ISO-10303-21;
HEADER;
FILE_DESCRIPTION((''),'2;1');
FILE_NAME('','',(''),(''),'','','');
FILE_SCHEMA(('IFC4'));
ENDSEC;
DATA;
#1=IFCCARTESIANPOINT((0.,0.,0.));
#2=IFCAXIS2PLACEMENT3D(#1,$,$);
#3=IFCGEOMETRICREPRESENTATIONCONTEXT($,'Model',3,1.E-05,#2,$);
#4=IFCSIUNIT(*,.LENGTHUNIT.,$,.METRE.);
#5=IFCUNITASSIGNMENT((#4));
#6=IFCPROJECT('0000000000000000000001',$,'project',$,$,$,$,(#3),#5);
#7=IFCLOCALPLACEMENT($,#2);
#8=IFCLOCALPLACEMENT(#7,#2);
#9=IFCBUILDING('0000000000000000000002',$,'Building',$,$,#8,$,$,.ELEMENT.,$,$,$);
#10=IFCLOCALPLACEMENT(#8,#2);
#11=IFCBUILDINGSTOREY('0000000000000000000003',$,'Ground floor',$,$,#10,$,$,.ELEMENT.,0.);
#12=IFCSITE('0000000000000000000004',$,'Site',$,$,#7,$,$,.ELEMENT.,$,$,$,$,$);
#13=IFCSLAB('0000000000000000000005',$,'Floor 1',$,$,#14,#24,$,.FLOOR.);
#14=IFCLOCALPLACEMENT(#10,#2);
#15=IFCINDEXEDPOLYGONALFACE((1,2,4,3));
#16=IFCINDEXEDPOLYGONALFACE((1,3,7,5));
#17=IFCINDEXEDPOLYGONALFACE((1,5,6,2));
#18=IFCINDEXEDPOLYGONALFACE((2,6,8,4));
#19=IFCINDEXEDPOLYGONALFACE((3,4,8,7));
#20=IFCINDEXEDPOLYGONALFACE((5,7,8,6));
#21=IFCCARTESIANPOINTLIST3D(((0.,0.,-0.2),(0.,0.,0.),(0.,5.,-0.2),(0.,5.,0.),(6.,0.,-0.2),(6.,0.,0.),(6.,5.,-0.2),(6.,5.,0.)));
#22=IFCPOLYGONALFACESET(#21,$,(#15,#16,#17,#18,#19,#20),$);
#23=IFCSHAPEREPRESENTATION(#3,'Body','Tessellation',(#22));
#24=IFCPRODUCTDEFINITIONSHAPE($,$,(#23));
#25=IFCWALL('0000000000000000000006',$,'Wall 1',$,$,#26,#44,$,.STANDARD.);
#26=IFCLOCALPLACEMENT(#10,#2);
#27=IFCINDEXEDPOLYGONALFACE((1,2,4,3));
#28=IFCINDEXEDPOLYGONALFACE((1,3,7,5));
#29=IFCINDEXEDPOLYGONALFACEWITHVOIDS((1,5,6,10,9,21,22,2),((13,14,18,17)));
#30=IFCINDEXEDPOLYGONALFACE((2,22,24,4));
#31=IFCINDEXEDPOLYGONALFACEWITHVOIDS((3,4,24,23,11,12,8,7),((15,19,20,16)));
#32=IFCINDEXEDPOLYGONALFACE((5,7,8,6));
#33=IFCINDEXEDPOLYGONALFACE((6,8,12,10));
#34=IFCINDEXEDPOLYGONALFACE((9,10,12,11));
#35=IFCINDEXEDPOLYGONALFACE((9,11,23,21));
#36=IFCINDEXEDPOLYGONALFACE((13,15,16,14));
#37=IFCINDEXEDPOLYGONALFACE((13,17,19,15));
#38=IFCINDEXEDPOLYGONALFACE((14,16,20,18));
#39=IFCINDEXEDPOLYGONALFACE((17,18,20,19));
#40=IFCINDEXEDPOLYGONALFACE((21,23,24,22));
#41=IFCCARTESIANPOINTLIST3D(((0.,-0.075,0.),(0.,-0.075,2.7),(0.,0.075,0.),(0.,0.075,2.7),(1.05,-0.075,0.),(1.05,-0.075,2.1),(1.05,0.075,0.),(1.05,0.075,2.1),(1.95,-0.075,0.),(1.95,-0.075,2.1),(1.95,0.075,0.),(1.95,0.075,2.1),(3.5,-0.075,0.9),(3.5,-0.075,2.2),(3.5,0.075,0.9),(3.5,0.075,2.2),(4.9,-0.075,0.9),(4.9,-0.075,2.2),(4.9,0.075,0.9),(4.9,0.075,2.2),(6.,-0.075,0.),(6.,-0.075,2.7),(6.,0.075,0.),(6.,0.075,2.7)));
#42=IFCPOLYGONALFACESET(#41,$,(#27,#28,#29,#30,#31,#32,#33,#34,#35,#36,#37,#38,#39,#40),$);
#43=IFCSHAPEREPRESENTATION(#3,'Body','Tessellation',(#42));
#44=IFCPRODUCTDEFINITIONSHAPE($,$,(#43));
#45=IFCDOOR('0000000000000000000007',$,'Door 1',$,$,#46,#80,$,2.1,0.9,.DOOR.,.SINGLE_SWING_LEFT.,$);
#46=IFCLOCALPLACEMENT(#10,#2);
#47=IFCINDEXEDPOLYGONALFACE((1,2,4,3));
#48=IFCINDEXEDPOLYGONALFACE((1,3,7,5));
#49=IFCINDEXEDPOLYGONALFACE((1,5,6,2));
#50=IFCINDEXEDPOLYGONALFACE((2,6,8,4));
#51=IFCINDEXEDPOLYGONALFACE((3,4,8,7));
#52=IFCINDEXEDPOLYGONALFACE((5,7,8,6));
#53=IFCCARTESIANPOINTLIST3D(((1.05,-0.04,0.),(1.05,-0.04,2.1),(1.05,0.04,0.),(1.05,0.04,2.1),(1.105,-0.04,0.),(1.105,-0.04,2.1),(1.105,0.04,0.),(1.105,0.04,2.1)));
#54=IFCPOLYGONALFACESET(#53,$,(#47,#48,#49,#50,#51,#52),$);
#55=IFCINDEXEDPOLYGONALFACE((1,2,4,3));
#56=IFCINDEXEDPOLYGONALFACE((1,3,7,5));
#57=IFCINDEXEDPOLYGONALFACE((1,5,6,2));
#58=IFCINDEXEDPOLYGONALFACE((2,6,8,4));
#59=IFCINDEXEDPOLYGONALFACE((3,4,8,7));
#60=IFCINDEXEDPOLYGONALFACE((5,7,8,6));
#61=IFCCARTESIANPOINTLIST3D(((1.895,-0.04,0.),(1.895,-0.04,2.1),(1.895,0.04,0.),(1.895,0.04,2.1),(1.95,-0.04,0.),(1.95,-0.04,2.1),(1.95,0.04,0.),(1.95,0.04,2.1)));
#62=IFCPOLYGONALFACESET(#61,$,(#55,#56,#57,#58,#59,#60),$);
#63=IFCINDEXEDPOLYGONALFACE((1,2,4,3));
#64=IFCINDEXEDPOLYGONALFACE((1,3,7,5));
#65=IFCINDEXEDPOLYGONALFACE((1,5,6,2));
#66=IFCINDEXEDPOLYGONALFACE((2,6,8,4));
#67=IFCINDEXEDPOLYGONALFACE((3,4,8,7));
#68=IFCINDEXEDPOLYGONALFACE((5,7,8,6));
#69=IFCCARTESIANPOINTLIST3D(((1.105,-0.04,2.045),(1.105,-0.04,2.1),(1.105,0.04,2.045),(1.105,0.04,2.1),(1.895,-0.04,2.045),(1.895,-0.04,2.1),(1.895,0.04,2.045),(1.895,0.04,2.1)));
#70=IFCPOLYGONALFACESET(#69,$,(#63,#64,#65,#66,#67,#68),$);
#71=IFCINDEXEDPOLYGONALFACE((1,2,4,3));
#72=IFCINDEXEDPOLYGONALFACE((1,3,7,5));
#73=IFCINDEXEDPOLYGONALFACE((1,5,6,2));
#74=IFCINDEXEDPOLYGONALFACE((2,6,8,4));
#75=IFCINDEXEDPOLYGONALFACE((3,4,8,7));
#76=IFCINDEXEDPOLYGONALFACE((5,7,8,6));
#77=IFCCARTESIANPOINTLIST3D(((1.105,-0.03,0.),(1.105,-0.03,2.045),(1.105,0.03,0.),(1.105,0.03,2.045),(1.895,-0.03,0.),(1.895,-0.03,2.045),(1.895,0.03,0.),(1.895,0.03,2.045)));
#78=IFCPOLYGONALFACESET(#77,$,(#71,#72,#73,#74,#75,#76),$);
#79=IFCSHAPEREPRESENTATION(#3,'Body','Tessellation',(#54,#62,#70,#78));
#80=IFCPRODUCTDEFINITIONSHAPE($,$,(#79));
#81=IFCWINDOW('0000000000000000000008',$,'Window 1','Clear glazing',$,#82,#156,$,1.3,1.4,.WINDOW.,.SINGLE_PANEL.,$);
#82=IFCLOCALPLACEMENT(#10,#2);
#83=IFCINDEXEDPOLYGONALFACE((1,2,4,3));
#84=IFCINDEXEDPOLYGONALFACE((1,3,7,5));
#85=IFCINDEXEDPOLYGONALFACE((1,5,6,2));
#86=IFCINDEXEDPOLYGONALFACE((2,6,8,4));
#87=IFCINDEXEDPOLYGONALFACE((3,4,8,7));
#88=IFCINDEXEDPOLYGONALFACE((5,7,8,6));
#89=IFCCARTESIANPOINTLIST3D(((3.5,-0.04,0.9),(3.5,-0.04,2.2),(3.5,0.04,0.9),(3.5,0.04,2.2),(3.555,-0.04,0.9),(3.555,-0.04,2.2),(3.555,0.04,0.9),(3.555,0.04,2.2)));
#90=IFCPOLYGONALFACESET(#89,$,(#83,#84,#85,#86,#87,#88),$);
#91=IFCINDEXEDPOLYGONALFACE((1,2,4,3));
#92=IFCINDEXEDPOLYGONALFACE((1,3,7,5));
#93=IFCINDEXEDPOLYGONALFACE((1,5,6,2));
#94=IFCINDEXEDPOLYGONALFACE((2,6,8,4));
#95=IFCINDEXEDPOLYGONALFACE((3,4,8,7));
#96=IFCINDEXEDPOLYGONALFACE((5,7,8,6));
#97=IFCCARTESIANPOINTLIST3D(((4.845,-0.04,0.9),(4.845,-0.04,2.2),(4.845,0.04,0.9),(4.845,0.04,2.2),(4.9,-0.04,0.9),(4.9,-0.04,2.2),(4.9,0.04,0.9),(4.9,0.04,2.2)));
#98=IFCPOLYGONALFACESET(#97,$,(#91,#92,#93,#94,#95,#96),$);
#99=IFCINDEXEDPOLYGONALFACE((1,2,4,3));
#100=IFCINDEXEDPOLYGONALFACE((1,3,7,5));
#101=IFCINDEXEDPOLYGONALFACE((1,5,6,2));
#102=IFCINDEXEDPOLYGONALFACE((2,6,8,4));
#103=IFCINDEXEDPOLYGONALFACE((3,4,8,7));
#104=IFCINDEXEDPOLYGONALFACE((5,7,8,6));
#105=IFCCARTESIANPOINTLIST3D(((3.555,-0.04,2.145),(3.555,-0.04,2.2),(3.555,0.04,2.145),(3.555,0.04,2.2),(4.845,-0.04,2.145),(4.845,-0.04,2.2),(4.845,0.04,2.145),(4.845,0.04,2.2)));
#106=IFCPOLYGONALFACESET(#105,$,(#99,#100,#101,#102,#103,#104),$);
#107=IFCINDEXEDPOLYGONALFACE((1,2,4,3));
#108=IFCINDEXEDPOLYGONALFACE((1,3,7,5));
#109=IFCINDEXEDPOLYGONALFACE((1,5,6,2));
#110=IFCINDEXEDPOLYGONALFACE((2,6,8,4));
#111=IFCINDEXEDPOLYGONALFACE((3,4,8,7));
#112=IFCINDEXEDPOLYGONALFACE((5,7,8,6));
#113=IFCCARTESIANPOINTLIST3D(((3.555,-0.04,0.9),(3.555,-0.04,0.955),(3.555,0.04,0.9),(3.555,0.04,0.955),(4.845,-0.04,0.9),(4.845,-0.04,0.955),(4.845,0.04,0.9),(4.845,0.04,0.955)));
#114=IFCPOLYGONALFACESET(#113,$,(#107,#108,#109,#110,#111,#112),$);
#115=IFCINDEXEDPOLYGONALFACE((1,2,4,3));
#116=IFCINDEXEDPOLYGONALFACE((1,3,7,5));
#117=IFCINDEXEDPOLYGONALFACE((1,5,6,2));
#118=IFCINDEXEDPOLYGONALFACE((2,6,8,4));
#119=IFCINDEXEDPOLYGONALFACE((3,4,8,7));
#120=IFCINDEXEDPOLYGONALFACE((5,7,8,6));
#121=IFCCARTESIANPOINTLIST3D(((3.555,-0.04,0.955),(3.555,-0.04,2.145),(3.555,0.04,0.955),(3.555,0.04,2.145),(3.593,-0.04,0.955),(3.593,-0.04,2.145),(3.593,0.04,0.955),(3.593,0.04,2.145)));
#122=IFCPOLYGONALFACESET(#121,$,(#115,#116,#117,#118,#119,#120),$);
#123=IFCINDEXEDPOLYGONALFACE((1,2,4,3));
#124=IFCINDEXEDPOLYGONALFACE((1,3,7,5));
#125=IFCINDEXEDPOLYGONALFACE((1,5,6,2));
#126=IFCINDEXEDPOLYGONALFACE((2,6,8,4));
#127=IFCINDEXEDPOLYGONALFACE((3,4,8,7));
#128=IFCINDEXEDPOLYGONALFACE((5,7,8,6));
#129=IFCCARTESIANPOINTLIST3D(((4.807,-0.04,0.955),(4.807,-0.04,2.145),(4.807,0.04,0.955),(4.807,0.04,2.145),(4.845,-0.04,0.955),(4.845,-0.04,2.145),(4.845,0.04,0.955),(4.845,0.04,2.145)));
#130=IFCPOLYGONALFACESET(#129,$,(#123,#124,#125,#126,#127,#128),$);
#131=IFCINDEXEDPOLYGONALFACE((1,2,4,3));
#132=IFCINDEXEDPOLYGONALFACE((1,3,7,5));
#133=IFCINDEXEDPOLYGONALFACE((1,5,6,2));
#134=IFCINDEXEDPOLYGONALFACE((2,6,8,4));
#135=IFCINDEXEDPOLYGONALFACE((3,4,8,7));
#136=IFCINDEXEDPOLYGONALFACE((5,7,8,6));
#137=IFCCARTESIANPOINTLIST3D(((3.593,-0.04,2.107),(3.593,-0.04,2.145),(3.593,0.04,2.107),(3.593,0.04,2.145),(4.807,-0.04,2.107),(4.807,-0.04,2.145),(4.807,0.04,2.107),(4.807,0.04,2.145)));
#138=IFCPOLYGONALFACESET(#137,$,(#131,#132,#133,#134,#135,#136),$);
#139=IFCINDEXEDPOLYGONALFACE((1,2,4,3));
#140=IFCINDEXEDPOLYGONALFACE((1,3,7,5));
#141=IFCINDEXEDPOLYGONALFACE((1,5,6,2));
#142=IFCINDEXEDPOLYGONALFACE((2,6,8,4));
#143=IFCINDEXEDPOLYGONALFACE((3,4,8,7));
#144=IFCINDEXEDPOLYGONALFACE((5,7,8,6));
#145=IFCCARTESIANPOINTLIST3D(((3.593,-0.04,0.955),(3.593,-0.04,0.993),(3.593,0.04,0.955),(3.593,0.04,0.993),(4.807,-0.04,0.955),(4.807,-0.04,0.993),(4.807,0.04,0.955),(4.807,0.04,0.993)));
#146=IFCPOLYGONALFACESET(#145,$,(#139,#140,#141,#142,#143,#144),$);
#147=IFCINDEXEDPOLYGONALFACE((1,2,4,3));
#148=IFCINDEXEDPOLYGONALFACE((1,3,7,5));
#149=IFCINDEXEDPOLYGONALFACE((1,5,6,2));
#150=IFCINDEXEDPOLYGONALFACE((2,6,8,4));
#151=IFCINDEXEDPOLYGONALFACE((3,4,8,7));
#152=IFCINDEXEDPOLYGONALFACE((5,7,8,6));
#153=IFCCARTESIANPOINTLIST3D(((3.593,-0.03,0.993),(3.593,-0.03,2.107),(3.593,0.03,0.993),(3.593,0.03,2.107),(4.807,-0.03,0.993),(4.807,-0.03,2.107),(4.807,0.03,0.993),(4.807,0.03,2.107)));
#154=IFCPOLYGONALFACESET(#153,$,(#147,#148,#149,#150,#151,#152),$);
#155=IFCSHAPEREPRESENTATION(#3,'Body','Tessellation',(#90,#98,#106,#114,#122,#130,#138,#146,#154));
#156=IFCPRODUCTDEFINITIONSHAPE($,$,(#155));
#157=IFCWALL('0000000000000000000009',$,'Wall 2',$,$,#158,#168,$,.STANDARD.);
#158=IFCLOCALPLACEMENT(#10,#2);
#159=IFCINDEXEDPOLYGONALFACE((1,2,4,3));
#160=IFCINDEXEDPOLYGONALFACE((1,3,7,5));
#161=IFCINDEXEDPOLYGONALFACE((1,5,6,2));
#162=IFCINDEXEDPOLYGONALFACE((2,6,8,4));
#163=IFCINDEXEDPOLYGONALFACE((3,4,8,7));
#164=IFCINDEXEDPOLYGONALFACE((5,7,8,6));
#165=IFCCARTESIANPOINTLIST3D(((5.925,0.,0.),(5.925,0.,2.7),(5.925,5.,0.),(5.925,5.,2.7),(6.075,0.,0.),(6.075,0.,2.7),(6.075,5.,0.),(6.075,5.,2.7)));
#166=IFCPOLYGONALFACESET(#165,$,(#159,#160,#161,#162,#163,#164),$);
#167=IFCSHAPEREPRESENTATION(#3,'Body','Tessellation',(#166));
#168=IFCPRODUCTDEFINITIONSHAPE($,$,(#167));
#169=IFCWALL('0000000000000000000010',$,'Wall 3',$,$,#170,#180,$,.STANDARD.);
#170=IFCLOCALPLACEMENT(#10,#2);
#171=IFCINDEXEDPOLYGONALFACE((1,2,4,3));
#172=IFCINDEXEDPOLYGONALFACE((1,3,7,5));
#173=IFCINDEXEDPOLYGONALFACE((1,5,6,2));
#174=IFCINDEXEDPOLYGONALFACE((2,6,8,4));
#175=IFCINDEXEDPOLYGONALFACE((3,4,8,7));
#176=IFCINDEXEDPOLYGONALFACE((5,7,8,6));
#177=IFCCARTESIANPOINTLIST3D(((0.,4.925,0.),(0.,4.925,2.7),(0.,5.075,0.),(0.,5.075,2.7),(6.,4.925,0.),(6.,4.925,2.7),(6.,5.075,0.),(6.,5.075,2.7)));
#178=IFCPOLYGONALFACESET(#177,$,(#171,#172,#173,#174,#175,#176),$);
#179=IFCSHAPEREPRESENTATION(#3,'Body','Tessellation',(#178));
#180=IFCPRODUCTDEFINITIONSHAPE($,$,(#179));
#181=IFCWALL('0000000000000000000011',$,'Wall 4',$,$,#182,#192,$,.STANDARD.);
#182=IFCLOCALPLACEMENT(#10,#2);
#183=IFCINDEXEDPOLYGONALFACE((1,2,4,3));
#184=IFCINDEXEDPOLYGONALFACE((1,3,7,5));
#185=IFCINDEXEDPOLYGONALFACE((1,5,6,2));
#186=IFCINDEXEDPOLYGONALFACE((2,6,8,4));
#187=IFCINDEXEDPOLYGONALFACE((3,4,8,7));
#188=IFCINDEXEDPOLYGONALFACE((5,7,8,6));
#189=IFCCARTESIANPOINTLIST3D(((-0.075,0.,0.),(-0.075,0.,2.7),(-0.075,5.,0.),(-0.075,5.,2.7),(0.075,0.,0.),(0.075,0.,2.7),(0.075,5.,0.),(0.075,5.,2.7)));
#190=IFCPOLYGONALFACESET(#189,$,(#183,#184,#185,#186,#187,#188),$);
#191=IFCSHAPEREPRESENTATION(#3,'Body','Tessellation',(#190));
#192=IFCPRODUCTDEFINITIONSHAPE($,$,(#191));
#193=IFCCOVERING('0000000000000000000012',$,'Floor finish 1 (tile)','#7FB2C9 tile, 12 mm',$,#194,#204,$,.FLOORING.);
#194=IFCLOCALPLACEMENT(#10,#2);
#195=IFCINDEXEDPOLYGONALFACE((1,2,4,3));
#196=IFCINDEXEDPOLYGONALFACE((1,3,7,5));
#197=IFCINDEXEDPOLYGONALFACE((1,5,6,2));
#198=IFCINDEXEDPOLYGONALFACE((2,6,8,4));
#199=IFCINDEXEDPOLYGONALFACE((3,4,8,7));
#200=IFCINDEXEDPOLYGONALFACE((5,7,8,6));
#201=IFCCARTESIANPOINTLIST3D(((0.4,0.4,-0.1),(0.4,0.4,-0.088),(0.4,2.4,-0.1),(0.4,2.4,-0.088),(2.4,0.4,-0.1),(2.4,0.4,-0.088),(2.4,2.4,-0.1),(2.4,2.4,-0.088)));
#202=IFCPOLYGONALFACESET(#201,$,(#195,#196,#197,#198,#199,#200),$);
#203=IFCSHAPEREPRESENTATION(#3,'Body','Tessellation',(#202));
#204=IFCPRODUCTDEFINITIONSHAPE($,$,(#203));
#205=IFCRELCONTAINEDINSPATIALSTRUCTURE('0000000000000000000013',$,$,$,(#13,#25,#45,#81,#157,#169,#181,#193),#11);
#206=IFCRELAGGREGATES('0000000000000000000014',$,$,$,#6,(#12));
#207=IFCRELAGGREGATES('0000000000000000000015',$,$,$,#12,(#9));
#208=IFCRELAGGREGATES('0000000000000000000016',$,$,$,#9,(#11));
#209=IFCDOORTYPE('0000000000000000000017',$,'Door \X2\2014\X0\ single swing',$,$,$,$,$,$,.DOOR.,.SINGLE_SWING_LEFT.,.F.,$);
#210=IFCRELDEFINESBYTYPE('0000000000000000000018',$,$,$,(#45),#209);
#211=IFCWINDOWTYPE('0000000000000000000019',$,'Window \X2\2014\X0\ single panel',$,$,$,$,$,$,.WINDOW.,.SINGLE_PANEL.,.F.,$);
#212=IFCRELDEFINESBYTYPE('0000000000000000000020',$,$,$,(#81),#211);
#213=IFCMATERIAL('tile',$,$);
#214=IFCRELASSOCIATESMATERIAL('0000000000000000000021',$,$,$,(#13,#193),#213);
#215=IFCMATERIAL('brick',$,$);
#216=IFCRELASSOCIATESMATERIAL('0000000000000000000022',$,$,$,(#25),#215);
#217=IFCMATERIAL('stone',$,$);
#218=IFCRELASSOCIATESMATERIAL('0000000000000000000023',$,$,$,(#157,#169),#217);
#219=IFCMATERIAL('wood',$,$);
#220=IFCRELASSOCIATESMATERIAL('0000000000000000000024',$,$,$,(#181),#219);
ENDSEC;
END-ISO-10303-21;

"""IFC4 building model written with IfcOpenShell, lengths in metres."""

from ifc_helpers import new_model, si_unit, frame, frame_2d, origin, origin_with_axes, place, context, project, spatial, polyline, rectangle, outline, extrude, material, type_object, element, fill, save


model = new_model("IFC4")

# Units and contexts
model_context = context("Model", 3, precision=1e-05, world=origin())
ifc_project = project(units=[si_unit("LENGTHUNIT", "METRE")], contexts=[model_context])

# Site, building, storey
site_placement = place(None, origin())
site = spatial("IfcSite", under=ifc_project, at=site_placement, Name="Site", CompositionType="ELEMENT")
building_placement = place(site_placement, origin())
building = spatial("IfcBuilding", under=site, at=building_placement, Name="Building", CompositionType="ELEMENT")
storey_placement = place(building_placement, origin())
storey = spatial("IfcBuildingStorey", under=building, at=storey_placement, Name="Ground floor", CompositionType="ELEMENT", Elevation=0.0)

# Slab
ifc_material_1 = material(Name="tile")
slab_placement = place(storey_placement, frame((0.0, 0.0, -0.2), z_axis=(0.0, 0.0, 1.0), x_axis=(1.0, 0.0, 0.0)))
element("IfcSlab", 1, at=slab_placement, inside=storey, material=ifc_material_1, Name="Floor 1", PredefinedType="FLOOR", context=model_context, shape_type="SweptSolid", body=[
    extrude(outline(polyline([(0.0, 0.0), (6.0, 0.0), (6.0, 5.0), (0.0, 5.0), (0.0, 0.0)])), origin(), (0.0, 0.0, 1.0), 0.2),
])

# Wall, openings, door, window
ifc_material_2 = material(Name="brick")
wall_1_placement = place(storey_placement, origin_with_axes())
wall_1 = element("IfcWall", 2, at=wall_1_placement, inside=storey, material=ifc_material_2, Name="Wall 1", PredefinedType="STANDARD", context=model_context, shape_type="SweptSolid", body=[
    extrude(rectangle(XDim=6.0, YDim=0.15, at=frame_2d((3.0, 0.0))), origin(), (0.0, 0.0, 1.0), 2.7),
])
opening_1_placement = place(storey_placement, frame((1.05, 0.0, 0.0), z_axis=(0.0, 0.0, 1.0), x_axis=(1.0, 0.0, 0.0)))
opening_1 = element("IfcOpeningElement", 3, at=opening_1_placement, cuts=wall_1, PredefinedType="OPENING", context=model_context, shape_type="SweptSolid", body=[
    extrude(rectangle(XDim=0.9, YDim=0.21, at=frame_2d((0.45, 0.0))), origin(), (0.0, 0.0, 1.0), 2.1),
])
opening_2_placement = place(storey_placement, frame((3.5, 0.0, 0.9), z_axis=(0.0, 0.0, 1.0), x_axis=(1.0, 0.0, 0.0)))
opening_2 = element("IfcOpeningElement", 4, at=opening_2_placement, cuts=wall_1, PredefinedType="OPENING", context=model_context, shape_type="SweptSolid", body=[
    extrude(rectangle(XDim=1.4, YDim=0.21, at=frame_2d((0.7, 0.0))), origin(), (0.0, 0.0, 1.0), 1.3),
])
door_type = type_object("IfcDoorType", Name="Door — single swing", OperationType="SINGLE_SWING_LEFT", ParameterTakesPrecedence=False, PredefinedType="DOOR")
door_placement = place(storey_placement, frame((1.05, 0.0, 0.0), z_axis=(0.0, 0.0, 1.0), x_axis=(1.0, 0.0, 0.0)))
door = element("IfcDoor", 5, at=door_placement, inside=storey, type_object=door_type, Name="Door 1", OperationType="SINGLE_SWING_LEFT", OverallHeight=2.1, OverallWidth=0.9, PredefinedType="DOOR", context=model_context, shape_type="SweptSolid", body=[
    extrude(rectangle(XDim=0.055, YDim=0.08, at=frame_2d((0.0275, 0.0))), origin(), (0.0, 0.0, 1.0), 2.1),
    extrude(rectangle(XDim=0.055, YDim=0.08, at=frame_2d((0.8725, 0.0))), origin(), (0.0, 0.0, 1.0), 2.1),
    extrude(rectangle(XDim=0.79, YDim=0.08, at=frame_2d((0.45, 0.0))), frame((0.0, 0.0, 2.045)), (0.0, 0.0, 1.0), 0.055),
    extrude(rectangle(XDim=0.79, YDim=0.06, at=frame_2d((0.45, 0.0))), origin(), (0.0, 0.0, 1.0), 2.045),
])
fill(opening_1, door)
window_type = type_object("IfcWindowType", Name="Window — single panel", ParameterTakesPrecedence=False, PartitioningType="SINGLE_PANEL", PredefinedType="WINDOW")
window_placement = place(storey_placement, frame((3.5, 0.0, 0.9), z_axis=(0.0, 0.0, 1.0), x_axis=(1.0, 0.0, 0.0)))
window = element("IfcWindow", 6, at=window_placement, inside=storey, type_object=window_type, Name="Window 1", Description="Clear glazing", OverallHeight=1.3, OverallWidth=1.4, PartitioningType="SINGLE_PANEL", PredefinedType="WINDOW", context=model_context, shape_type="SweptSolid", body=[
    extrude(rectangle(XDim=0.055, YDim=0.08, at=frame_2d((0.0275, 0.0))), origin(), (0.0, 0.0, 1.0), 1.3),
    extrude(rectangle(XDim=0.055, YDim=0.08, at=frame_2d((1.3725, 0.0))), origin(), (0.0, 0.0, 1.0), 1.3),
    extrude(rectangle(XDim=1.29, YDim=0.08, at=frame_2d((0.7, 0.0))), frame((0.0, 0.0, 1.245)), (0.0, 0.0, 1.0), 0.055),
    extrude(rectangle(XDim=1.29, YDim=0.08, at=frame_2d((0.7, 0.0))), origin(), (0.0, 0.0, 1.0), 0.055),
    extrude(rectangle(XDim=0.038, YDim=0.08, at=frame_2d((0.074, 0.0))), frame((0.0, 0.0, 0.055)), (0.0, 0.0, 1.0), 1.19),
    extrude(rectangle(XDim=0.038, YDim=0.08, at=frame_2d((1.326, 0.0))), frame((0.0, 0.0, 0.055)), (0.0, 0.0, 1.0), 1.19),
    extrude(rectangle(XDim=1.214, YDim=0.08, at=frame_2d((0.7, 0.0))), frame((0.0, 0.0, 1.207)), (0.0, 0.0, 1.0), 0.038),
    extrude(rectangle(XDim=1.214, YDim=0.08, at=frame_2d((0.7, 0.0))), frame((0.0, 0.0, 0.055)), (0.0, 0.0, 1.0), 0.038),
    extrude(rectangle(XDim=1.214, YDim=0.06, at=frame_2d((0.7, 0.0))), frame((0.0, 0.0, 0.093)), (0.0, 0.0, 1.0), 1.114),
])
fill(opening_2, window)

# Walls
ifc_material_3 = material(Name="stone")
wall_2_placement = place(storey_placement, frame((6.0, 0.0, 0.0), z_axis=(0.0, 0.0, 1.0), x_axis=(0.0, 1.0, 0.0)))
element("IfcWall", 7, at=wall_2_placement, inside=storey, material=ifc_material_3, Name="Wall 2", PredefinedType="STANDARD", context=model_context, shape_type="SweptSolid", body=[
    extrude(rectangle(XDim=5.0, YDim=0.15, at=frame_2d((2.5, 0.0))), origin(), (0.0, 0.0, 1.0), 2.7),
])
wall_3_placement = place(storey_placement, frame((6.0, 5.0, 0.0), z_axis=(0.0, 0.0, 1.0), x_axis=(-1.0, 0.0, 0.0)))
element("IfcWall", 8, at=wall_3_placement, inside=storey, material=ifc_material_3, Name="Wall 3", PredefinedType="STANDARD", context=model_context, shape_type="SweptSolid", body=[
    extrude(rectangle(XDim=6.0, YDim=0.15, at=frame_2d((3.0, 0.0))), origin(), (0.0, 0.0, 1.0), 2.7),
])
ifc_material_4 = material(Name="wood")
wall_4_placement = place(storey_placement, frame((0.0, 5.0, 0.0), z_axis=(0.0, 0.0, 1.0), x_axis=(0.0, -1.0, 0.0)))
element("IfcWall", 9, at=wall_4_placement, inside=storey, material=ifc_material_4, Name="Wall 4", PredefinedType="STANDARD", context=model_context, shape_type="SweptSolid", body=[
    extrude(rectangle(XDim=5.0, YDim=0.15, at=frame_2d((2.5, 0.0))), origin(), (0.0, 0.0, 1.0), 2.7),
])

# Covering
covering_1_placement = place(storey_placement, frame((0.0, 0.0, -0.1), z_axis=(0.0, 0.0, 1.0), x_axis=(1.0, 0.0, 0.0)))
element("IfcCovering", 10, at=covering_1_placement, inside=storey, material=ifc_material_1, Name="Floor finish 1 (tile)", Description="#7FB2C9 tile, 12 mm", PredefinedType="FLOORING", context=model_context, shape_type="SweptSolid", body=[
    extrude(outline(polyline([(0.4, 0.4), (2.4, 0.4), (2.4, 2.4), (0.4, 2.4), (0.4, 0.4)])), origin(), (0.0, 0.0, 1.0), 0.012),
])

save(model, "model.ifc")
